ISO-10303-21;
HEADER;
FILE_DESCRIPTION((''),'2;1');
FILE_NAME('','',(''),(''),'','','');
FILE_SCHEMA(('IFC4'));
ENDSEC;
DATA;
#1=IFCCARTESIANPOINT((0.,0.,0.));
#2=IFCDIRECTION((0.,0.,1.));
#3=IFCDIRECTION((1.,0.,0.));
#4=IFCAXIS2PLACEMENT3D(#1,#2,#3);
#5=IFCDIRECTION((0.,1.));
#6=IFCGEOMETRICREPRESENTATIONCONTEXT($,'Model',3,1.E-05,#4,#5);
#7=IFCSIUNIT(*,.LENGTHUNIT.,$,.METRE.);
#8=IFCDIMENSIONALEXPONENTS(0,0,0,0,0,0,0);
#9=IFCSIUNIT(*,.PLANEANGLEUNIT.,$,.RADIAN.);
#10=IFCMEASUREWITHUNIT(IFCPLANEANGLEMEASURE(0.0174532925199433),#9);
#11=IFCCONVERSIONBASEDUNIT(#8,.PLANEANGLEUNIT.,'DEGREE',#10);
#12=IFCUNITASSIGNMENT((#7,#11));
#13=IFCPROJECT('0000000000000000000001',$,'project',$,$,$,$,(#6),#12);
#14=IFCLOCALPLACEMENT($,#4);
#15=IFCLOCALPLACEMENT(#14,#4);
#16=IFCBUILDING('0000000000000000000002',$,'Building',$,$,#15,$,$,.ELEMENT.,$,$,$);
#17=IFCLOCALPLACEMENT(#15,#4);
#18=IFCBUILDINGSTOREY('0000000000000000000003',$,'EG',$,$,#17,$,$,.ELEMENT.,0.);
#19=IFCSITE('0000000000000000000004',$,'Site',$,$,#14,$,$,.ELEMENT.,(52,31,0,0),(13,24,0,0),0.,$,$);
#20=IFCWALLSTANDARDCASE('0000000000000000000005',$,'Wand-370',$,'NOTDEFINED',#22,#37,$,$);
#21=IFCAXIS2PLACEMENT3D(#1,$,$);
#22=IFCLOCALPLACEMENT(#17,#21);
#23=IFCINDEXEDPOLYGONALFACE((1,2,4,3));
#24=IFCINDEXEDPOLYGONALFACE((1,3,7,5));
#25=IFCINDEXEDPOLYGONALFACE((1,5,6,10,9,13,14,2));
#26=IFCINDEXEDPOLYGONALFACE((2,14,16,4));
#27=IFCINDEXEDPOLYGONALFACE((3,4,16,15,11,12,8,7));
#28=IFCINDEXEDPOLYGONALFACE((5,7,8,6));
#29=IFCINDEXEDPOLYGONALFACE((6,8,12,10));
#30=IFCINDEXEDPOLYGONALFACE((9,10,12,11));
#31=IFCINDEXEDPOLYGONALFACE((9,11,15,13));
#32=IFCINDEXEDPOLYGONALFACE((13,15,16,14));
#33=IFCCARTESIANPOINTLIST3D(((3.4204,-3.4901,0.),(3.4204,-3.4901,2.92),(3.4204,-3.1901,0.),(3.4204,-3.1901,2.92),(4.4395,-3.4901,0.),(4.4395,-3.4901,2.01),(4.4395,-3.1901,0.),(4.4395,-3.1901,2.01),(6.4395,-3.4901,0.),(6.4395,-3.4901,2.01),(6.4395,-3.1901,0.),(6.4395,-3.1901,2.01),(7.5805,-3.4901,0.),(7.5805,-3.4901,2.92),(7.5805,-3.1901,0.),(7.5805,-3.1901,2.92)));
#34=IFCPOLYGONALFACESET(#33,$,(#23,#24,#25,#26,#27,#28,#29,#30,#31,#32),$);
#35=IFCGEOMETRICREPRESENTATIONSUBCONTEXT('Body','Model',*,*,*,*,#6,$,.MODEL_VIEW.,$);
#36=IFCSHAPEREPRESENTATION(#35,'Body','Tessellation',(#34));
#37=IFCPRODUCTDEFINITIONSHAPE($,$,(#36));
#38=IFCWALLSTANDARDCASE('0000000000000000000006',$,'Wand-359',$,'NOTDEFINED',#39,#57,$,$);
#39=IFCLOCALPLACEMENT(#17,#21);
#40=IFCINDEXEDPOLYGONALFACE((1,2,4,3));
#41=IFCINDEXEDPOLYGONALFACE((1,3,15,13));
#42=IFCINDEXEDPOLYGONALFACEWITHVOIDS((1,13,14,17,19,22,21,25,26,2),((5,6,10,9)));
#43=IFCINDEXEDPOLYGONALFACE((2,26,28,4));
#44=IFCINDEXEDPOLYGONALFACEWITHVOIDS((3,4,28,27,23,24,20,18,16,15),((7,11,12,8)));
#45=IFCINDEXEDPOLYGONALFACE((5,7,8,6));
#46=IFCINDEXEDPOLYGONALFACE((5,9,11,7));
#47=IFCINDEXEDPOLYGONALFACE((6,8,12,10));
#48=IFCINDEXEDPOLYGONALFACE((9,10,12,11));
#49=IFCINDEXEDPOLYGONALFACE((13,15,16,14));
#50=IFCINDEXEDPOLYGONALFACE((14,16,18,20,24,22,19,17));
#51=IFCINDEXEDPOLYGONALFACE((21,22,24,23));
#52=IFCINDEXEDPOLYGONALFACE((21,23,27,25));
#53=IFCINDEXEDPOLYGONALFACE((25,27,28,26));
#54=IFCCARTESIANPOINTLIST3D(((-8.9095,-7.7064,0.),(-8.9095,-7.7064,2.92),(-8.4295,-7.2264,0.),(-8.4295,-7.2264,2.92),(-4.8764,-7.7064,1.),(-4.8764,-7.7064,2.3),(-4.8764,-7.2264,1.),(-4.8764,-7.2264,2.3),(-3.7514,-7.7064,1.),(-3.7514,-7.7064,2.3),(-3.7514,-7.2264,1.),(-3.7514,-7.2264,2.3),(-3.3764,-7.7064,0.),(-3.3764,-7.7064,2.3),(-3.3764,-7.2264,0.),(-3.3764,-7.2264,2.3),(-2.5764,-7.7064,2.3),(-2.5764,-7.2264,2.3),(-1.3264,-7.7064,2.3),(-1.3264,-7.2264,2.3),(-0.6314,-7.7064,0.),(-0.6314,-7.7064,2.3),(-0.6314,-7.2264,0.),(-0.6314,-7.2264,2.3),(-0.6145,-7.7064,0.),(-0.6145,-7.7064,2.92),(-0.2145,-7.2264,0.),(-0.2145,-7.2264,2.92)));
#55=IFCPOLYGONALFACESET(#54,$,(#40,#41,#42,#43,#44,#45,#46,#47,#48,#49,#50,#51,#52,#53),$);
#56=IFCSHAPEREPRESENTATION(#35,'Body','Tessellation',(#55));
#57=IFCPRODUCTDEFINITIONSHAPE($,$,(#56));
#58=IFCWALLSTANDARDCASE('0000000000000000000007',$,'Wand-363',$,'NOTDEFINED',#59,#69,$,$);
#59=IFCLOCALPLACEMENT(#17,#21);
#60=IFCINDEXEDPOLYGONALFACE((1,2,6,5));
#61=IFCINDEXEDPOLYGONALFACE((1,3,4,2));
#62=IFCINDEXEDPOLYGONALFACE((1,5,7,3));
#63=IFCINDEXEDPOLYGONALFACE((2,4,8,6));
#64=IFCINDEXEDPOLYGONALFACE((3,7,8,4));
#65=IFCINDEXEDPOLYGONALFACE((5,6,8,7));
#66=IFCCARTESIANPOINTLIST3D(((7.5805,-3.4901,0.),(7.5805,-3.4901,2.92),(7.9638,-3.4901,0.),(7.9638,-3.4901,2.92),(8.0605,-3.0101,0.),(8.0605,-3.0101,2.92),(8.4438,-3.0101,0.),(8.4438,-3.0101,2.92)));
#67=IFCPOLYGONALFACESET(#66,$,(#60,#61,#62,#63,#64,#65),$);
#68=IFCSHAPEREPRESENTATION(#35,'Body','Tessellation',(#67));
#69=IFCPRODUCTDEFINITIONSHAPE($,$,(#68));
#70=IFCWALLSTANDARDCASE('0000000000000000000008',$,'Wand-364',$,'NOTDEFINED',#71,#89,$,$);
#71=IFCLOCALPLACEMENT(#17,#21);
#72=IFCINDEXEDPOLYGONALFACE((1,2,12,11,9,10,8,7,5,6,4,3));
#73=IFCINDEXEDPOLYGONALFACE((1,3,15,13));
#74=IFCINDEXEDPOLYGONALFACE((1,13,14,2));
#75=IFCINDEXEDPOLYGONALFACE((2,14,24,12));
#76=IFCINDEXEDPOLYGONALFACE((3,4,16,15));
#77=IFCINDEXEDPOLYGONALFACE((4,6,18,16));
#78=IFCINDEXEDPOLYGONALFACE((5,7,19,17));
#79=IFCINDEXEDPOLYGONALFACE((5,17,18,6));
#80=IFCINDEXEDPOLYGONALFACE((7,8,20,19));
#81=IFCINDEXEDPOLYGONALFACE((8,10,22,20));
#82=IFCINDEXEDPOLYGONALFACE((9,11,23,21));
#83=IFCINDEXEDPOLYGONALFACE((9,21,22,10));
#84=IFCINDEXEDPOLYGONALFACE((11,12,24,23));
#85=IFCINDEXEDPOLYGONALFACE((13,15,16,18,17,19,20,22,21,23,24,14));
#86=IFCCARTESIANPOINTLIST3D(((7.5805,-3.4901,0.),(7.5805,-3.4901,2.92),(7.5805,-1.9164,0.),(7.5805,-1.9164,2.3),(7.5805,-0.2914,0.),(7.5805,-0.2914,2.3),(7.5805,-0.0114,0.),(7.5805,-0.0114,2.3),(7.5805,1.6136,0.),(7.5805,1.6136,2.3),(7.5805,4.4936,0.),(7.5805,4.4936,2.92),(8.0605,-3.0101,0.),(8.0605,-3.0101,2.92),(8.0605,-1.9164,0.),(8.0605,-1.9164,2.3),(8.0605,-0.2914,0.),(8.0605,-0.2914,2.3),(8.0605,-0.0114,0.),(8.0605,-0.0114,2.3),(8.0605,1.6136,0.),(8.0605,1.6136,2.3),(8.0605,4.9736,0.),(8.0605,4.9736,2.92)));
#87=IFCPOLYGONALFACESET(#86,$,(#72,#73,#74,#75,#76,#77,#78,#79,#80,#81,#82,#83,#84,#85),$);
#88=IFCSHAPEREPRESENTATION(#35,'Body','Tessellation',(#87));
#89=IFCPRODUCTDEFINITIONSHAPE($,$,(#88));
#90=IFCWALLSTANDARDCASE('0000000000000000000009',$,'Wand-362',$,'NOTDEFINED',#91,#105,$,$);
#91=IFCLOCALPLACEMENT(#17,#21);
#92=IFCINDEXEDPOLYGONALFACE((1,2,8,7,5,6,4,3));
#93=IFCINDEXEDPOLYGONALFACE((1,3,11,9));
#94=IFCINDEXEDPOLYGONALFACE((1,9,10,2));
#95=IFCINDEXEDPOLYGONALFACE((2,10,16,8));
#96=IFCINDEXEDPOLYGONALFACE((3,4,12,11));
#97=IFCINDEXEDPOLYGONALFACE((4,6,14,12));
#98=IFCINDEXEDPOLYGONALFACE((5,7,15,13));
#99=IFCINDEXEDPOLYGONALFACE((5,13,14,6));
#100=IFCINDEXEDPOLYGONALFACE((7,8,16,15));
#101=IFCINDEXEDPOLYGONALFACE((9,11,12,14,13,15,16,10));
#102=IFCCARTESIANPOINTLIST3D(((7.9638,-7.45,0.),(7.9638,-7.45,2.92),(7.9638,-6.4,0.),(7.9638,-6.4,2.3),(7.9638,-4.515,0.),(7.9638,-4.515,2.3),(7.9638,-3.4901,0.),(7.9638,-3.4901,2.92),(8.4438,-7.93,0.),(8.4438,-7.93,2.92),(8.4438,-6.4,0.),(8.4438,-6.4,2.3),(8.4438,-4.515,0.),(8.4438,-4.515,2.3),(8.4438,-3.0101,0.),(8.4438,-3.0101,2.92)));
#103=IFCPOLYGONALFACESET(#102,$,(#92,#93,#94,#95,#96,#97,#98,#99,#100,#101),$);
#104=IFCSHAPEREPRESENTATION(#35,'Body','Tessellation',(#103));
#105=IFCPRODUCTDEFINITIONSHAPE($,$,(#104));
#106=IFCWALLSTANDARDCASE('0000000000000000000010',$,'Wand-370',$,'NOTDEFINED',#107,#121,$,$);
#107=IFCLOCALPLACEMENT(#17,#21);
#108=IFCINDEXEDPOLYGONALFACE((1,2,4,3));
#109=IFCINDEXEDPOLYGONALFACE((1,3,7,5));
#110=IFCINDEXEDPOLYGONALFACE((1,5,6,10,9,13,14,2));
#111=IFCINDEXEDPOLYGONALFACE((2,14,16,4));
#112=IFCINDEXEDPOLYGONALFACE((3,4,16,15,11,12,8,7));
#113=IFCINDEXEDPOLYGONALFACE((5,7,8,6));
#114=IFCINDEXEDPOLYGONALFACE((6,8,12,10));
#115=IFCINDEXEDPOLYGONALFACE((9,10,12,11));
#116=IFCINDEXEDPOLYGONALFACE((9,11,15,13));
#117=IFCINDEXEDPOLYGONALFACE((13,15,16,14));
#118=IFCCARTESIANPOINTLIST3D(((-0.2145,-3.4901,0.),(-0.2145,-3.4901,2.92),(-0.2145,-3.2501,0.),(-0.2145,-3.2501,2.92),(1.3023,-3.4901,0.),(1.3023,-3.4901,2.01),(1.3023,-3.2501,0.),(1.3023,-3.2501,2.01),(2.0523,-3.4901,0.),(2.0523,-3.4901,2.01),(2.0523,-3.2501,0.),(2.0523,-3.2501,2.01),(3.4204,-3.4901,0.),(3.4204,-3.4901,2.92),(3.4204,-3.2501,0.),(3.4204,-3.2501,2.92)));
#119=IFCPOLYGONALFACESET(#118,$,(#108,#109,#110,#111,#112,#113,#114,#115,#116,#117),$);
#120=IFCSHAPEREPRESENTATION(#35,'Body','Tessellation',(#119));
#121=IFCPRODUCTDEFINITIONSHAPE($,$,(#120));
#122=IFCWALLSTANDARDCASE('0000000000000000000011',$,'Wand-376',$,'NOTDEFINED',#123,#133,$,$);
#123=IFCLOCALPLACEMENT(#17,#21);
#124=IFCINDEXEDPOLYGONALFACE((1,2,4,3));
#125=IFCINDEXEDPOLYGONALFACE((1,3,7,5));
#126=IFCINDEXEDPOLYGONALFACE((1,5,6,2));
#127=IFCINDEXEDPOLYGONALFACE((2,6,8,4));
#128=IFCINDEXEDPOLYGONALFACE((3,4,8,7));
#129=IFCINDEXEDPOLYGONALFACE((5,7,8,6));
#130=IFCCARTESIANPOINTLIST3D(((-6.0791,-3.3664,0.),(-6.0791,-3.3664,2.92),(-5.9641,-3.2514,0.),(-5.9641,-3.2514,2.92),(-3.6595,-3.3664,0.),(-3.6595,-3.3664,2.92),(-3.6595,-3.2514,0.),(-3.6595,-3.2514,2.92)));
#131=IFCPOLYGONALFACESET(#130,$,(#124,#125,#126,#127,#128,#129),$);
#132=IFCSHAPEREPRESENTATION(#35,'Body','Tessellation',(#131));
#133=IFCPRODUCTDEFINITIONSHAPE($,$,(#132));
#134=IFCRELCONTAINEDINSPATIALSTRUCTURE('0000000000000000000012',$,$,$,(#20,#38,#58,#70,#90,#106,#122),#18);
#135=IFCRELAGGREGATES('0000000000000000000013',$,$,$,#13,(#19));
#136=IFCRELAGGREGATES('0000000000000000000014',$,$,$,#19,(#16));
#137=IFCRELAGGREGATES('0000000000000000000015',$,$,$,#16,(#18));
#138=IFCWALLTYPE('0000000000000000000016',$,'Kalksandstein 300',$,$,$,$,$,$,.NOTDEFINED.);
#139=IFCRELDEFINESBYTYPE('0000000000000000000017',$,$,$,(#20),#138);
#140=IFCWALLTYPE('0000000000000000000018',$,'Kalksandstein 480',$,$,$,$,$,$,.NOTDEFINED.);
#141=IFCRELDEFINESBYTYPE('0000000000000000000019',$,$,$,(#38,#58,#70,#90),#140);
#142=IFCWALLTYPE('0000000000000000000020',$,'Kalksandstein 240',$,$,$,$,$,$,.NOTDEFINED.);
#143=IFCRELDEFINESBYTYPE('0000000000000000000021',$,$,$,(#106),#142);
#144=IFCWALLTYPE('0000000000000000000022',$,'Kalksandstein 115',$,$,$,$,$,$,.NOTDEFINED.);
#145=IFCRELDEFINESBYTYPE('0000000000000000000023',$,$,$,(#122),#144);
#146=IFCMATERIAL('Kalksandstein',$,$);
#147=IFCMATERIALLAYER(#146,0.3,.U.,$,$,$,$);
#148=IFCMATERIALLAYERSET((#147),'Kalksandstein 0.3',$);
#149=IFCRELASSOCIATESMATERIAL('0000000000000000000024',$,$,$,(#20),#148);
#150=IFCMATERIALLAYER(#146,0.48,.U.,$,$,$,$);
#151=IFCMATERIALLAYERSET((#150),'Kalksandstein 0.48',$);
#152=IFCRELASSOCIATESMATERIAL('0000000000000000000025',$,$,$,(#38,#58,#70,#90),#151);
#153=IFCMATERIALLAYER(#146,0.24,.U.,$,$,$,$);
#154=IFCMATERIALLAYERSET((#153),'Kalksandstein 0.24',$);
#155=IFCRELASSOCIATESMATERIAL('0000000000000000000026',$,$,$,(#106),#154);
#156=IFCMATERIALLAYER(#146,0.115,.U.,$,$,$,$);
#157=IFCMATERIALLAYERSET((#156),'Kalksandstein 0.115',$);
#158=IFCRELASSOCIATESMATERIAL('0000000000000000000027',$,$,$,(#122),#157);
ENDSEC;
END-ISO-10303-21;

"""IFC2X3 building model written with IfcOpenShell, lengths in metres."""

from ifc_helpers import new_model, entity, si_unit, converted_unit, direction, frame, origin_with_axes, origin_2d_with_axis, place, context, subcontext, project, spatial, polyline, rectangle, outline, extrude, material, layer, layer_set, layer_usage, type_object, element, save


model = new_model("IFC2X3")

# Units and contexts
model_context = context("Model", 3, precision=1e-05, world=origin_with_axes(), true_north=direction((0.0, 1.0)))
body_context = subcontext(model_context, "Body", "Model", "MODEL_VIEW")
ifc_project = project(units=[si_unit("LENGTHUNIT", "METRE"), converted_unit("PLANEANGLEUNIT", "DEGREE", entity("IfcPlaneAngleMeasure", 0.0174532925199433), si_unit("PLANEANGLEUNIT", "RADIAN"), dimensions=[0, 0, 0, 0, 0, 0, 0])], contexts=[model_context])

# Site, building, storey
site_placement = place(None, origin_with_axes())
site = spatial("IfcSite", under=ifc_project, at=site_placement, Name="Site", CompositionType="ELEMENT", RefLatitude=(52, 31, 0, 0), RefLongitude=(13, 24, 0, 0), RefElevation=0.0)
building_placement = place(site_placement, origin_with_axes())
building = spatial("IfcBuilding", under=site, at=building_placement, Name="Building", CompositionType="ELEMENT")
storey_placement = place(building_placement, origin_with_axes())
storey = spatial("IfcBuildingStorey", under=building, at=storey_placement, Name="EG", CompositionType="ELEMENT", Elevation=0.0)

# Wall, opening
ifc_material = material(Name="Kalksandstein")
ifc_layer_1 = layer(ifc_material, 0.3, ventilated="UNKNOWN")
ifc_layer_set_1 = layer_set([ifc_layer_1], Name="Kalksandstein 0.3")
ifc_layer_usage_1 = layer_usage(ifc_layer_set_1, "AXIS2", "NEGATIVE", 0.0)
wall_type_1 = type_object("IfcWallType", Name="Kalksandstein 300", PredefinedType="NOTDEFINED")
wall_1_placement = place(storey_placement, frame((7.5805, -3.4901, 0.0), z_axis=(0.0, 0.0, 1.0), x_axis=(-1.0, 0.0, 0.0)))
wall_1 = element("IfcWallStandardCase", 1, at=wall_1_placement, inside=storey, type_object=wall_type_1, material=ifc_layer_usage_1, Name="Wand-370", ObjectType="NOTDEFINED", context=body_context, shape_type="SweptSolid", body=[
    extrude(outline(polyline([(0.0, -0.3), (4.1602, -0.3), (4.1602, 0.0), (0.0, 0.0), (0.0, -0.3)])), origin_with_axes(), (0.0, 0.0, 1.0), 2.92),
])
opening_1_placement = place(wall_1_placement, frame((2.1411, 0.0, 0.0), z_axis=(0.0, 0.0, 1.0), x_axis=(1.0, 0.0, 0.0)))
element("IfcOpeningElement", 2, at=opening_1_placement, cuts=wall_1, context=body_context, shape_type="SweptSolid", body=[
    extrude(rectangle(XDim=2.0, YDim=2.01, at=origin_2d_with_axis()), frame((0.0, 0.3, 1.005), z_axis=(0.0, -1.0, 0.0), x_axis=(-1.0, 0.0, 0.0)), (0.0, 0.0, 1.0), 0.9),
])

# Wall, openings
ifc_layer_2 = layer(ifc_material, 0.48, ventilated="UNKNOWN")
ifc_layer_set_2 = layer_set([ifc_layer_2], Name="Kalksandstein 0.48")
ifc_layer_usage_2 = layer_usage(ifc_layer_set_2, "AXIS2", "POSITIVE", 0.0)
wall_type_2 = type_object("IfcWallType", Name="Kalksandstein 480", PredefinedType="NOTDEFINED")
wall_2_placement = place(storey_placement, frame((-8.9095, -7.7064, 0.0), z_axis=(0.0, 0.0, 1.0), x_axis=(1.0, 0.0, 0.0)))
wall_2 = element("IfcWallStandardCase", 3, at=wall_2_placement, inside=storey, type_object=wall_type_2, material=ifc_layer_usage_2, Name="Wand-359", ObjectType="NOTDEFINED", context=body_context, shape_type="SweptSolid", body=[
    extrude(outline(polyline([(0.0, 0.0), (8.295, 0.0), (8.695, 0.48), (0.48, 0.48), (0.0, 0.0)])), origin_with_axes(), (0.0, 0.0, 1.0), 2.92),
])
opening_2_placement = place(wall_2_placement, frame((5.9331, 0.0, 0.0), z_axis=(0.0, 0.0, 1.0), x_axis=(1.0, 0.0, 0.0)))
element("IfcOpeningElement", 4, at=opening_2_placement, cuts=wall_2, context=body_context, shape_type="SweptSolid", body=[
    extrude(rectangle(XDim=0.8, YDim=2.3, at=origin_2d_with_axis()), frame((0.0, 0.48, 1.15), z_axis=(0.0, -1.0, 0.0), x_axis=(-1.0, 0.0, 0.0)), (0.0, 0.0, 1.0), 1.44),
])
opening_3_placement = place(wall_2_placement, frame((4.5956, 0.0, 1.0), z_axis=(0.0, 0.0, 1.0), x_axis=(1.0, 0.0, 0.0)))
element("IfcOpeningElement", 5, at=opening_3_placement, cuts=wall_2, context=body_context, shape_type="SweptSolid", body=[
    extrude(rectangle(XDim=1.125, YDim=1.3, at=origin_2d_with_axis()), frame((0.0, 0.48, 0.65), z_axis=(0.0, -1.0, 0.0), x_axis=(-1.0, 0.0, 0.0)), (0.0, 0.0, 1.0), 1.44),
])
opening_4_placement = place(wall_2_placement, frame((7.9306, 0.0, 0.0), z_axis=(0.0, 0.0, 1.0), x_axis=(1.0, 0.0, 0.0)))
element("IfcOpeningElement", 6, at=opening_4_placement, cuts=wall_2, context=body_context, shape_type="SweptSolid", body=[
    extrude(rectangle(XDim=0.695, YDim=2.3, at=origin_2d_with_axis()), frame((0.0, 0.48, 1.15), z_axis=(0.0, -1.0, 0.0), x_axis=(-1.0, 0.0, 0.0)), (0.0, 0.0, 1.0), 1.44),
])
opening_5_placement = place(wall_2_placement, frame((6.9581, 0.0, 0.0), z_axis=(0.0, 0.0, 1.0), x_axis=(1.0, 0.0, 0.0)))
element("IfcOpeningElement", 7, at=opening_5_placement, cuts=wall_2, context=body_context, shape_type="SweptSolid", body=[
    extrude(rectangle(XDim=1.25, YDim=2.3, at=origin_2d_with_axis()), frame((0.0, 0.48, 1.15), z_axis=(0.0, -1.0, 0.0), x_axis=(1.0, 0.0, 0.0)), (0.0, 0.0, 1.0), 1.44),
])

# Wall
ifc_layer_usage_3 = layer_usage(ifc_layer_set_2, "AXIS2", "POSITIVE", 0.0)
wall_3_placement = place(storey_placement, frame((8.4438, -3.0101, 0.0), z_axis=(0.0, 0.0, 1.0), x_axis=(-1.0, 0.0, 0.0)))
element("IfcWallStandardCase", 8, at=wall_3_placement, inside=storey, type_object=wall_type_2, material=ifc_layer_usage_3, Name="Wand-363", ObjectType="NOTDEFINED", context=body_context, shape_type="SweptSolid", body=[
    extrude(outline(polyline([(0.0, 0.0), (0.3833, 0.0), (0.8633, 0.48), (0.48, 0.48), (0.0, 0.0)])), origin_with_axes(), (0.0, 0.0, 1.0), 2.92),
])

# Wall, openings
ifc_layer_usage_4 = layer_usage(ifc_layer_set_2, "AXIS2", "POSITIVE", 0.0)
wall_4_placement = place(storey_placement, frame((8.0605, -3.0101, 0.0), z_axis=(0.0, 0.0, 1.0), x_axis=(0.0, 1.0, 0.0)))
wall_4 = element("IfcWallStandardCase", 9, at=wall_4_placement, inside=storey, type_object=wall_type_2, material=ifc_layer_usage_4, Name="Wand-364", ObjectType="NOTDEFINED", context=body_context, shape_type="SweptSolid", body=[
    extrude(outline(polyline([(0.0, 0.0), (7.9838, 0.0), (7.5038, 0.48), (-0.48, 0.48), (0.0, 0.0)])), origin_with_axes(), (0.0, 0.0, 1.0), 2.92),
])
opening_6_placement = place(wall_4_placement, frame((1.9063, 0.0, 0.0), z_axis=(0.0, 0.0, 1.0), x_axis=(1.0, 0.0, 0.0)))
element("IfcOpeningElement", 10, at=opening_6_placement, cuts=wall_4, context=body_context, shape_type="SweptSolid", body=[
    extrude(rectangle(XDim=1.625, YDim=2.3, at=origin_2d_with_axis()), frame((0.0, 0.48, 1.15), z_axis=(0.0, -1.0, 0.0), x_axis=(-1.0, 0.0, 0.0)), (0.0, 0.0, 1.0), 1.44),
])
opening_7_placement = place(wall_4_placement, frame((3.8113, 0.0, 0.0), z_axis=(0.0, 0.0, 1.0), x_axis=(1.0, 0.0, 0.0)))
element("IfcOpeningElement", 11, at=opening_7_placement, cuts=wall_4, context=body_context, shape_type="SweptSolid", body=[
    extrude(rectangle(XDim=1.625, YDim=2.3, at=origin_2d_with_axis()), frame((0.0, 0.48, 1.15), z_axis=(0.0, -1.0, 0.0), x_axis=(-1.0, 0.0, 0.0)), (0.0, 0.0, 1.0), 1.44),
])

# Walls, openings
ifc_layer_usage_5 = layer_usage(ifc_layer_set_2, "AXIS2", "POSITIVE", 0.0)
wall_5_placement = place(storey_placement, frame((8.4438, -7.93, 0.0), z_axis=(0.0, 0.0, 1.0), x_axis=(0.0, 1.0, 0.0)))
wall_5 = element("IfcWallStandardCase", 12, at=wall_5_placement, inside=storey, type_object=wall_type_2, material=ifc_layer_usage_5, Name="Wand-362", ObjectType="NOTDEFINED", context=body_context, shape_type="SweptSolid", body=[
    extrude(outline(polyline([(0.0, 0.0), (4.9199, 0.0), (4.4399, 0.48), (0.48, 0.48), (0.0, 0.0)])), origin_with_axes(), (0.0, 0.0, 1.0), 2.92),
])
opening_8_placement = place(wall_5_placement, frame((2.4725, 0.0, 0.0), z_axis=(0.0, 0.0, 1.0), x_axis=(1.0, 0.0, 0.0)))
element("IfcOpeningElement", 13, at=opening_8_placement, cuts=wall_5, context=body_context, shape_type="SweptSolid", body=[
    extrude(rectangle(XDim=1.885, YDim=2.3, at=origin_2d_with_axis()), frame((0.0, 0.48, 1.15), z_axis=(0.0, -1.0, 0.0), x_axis=(-1.0, 0.0, 0.0)), (0.0, 0.0, 1.0), 1.44),
])
ifc_layer_3 = layer(ifc_material, 0.24, ventilated="UNKNOWN")
ifc_layer_set_3 = layer_set([ifc_layer_3], Name="Kalksandstein 0.24")
ifc_layer_usage_6 = layer_usage(ifc_layer_set_3, "AXIS2", "NEGATIVE", 0.0)
wall_type_3 = type_object("IfcWallType", Name="Kalksandstein 240", PredefinedType="NOTDEFINED")
wall_6_placement = place(storey_placement, frame((3.4204, -3.4901, 0.0), z_axis=(0.0, 0.0, 1.0), x_axis=(-1.0, 0.0, 0.0)))
wall_6 = element("IfcWallStandardCase", 14, at=wall_6_placement, inside=storey, type_object=wall_type_3, material=ifc_layer_usage_6, Name="Wand-370", ObjectType="NOTDEFINED", context=body_context, shape_type="SweptSolid", body=[
    extrude(outline(polyline([(0.0, -0.24), (3.6348, -0.24), (3.6348, 0.0), (0.0, 0.0), (0.0, -0.24)])), origin_with_axes(), (0.0, 0.0, 1.0), 2.92),
])
opening_9_placement = place(wall_6_placement, frame((1.7431, 0.0, 0.0), z_axis=(0.0, 0.0, 1.0), x_axis=(1.0, 0.0, 0.0)))
element("IfcOpeningElement", 15, at=opening_9_placement, cuts=wall_6, context=body_context, shape_type="SweptSolid", body=[
    extrude(rectangle(XDim=0.75, YDim=2.01, at=origin_2d_with_axis()), frame((0.0, 0.24, 1.005), z_axis=(0.0, -1.0, 0.0), x_axis=(-1.0, 0.0, 0.0)), (0.0, 0.0, 1.0), 0.72),
])

# Wall
ifc_layer_4 = layer(ifc_material, 0.115, ventilated="UNKNOWN")
ifc_layer_set_4 = layer_set([ifc_layer_4], Name="Kalksandstein 0.115")
ifc_layer_usage_7 = layer_usage(ifc_layer_set_4, "AXIS2", "NEGATIVE", 0.0)
wall_type_4 = type_object("IfcWallType", Name="Kalksandstein 115", PredefinedType="NOTDEFINED")
wall_7_placement = place(storey_placement, frame((-3.6595, -3.3664, 0.0), z_axis=(0.0, 0.0, 1.0), x_axis=(-1.0, 0.0, 0.0)))
element("IfcWallStandardCase", 16, at=wall_7_placement, inside=storey, type_object=wall_type_4, material=ifc_layer_usage_7, Name="Wand-376", ObjectType="NOTDEFINED", context=body_context, shape_type="SweptSolid", body=[
    extrude(outline(polyline([(0.0, -0.115), (2.3046, -0.115), (2.4196, 0.0), (0.0, 0.0), (0.0, -0.115)])), origin_with_axes(), (0.0, 0.0, 1.0), 2.92),
])

save(model, "model.ifc")
